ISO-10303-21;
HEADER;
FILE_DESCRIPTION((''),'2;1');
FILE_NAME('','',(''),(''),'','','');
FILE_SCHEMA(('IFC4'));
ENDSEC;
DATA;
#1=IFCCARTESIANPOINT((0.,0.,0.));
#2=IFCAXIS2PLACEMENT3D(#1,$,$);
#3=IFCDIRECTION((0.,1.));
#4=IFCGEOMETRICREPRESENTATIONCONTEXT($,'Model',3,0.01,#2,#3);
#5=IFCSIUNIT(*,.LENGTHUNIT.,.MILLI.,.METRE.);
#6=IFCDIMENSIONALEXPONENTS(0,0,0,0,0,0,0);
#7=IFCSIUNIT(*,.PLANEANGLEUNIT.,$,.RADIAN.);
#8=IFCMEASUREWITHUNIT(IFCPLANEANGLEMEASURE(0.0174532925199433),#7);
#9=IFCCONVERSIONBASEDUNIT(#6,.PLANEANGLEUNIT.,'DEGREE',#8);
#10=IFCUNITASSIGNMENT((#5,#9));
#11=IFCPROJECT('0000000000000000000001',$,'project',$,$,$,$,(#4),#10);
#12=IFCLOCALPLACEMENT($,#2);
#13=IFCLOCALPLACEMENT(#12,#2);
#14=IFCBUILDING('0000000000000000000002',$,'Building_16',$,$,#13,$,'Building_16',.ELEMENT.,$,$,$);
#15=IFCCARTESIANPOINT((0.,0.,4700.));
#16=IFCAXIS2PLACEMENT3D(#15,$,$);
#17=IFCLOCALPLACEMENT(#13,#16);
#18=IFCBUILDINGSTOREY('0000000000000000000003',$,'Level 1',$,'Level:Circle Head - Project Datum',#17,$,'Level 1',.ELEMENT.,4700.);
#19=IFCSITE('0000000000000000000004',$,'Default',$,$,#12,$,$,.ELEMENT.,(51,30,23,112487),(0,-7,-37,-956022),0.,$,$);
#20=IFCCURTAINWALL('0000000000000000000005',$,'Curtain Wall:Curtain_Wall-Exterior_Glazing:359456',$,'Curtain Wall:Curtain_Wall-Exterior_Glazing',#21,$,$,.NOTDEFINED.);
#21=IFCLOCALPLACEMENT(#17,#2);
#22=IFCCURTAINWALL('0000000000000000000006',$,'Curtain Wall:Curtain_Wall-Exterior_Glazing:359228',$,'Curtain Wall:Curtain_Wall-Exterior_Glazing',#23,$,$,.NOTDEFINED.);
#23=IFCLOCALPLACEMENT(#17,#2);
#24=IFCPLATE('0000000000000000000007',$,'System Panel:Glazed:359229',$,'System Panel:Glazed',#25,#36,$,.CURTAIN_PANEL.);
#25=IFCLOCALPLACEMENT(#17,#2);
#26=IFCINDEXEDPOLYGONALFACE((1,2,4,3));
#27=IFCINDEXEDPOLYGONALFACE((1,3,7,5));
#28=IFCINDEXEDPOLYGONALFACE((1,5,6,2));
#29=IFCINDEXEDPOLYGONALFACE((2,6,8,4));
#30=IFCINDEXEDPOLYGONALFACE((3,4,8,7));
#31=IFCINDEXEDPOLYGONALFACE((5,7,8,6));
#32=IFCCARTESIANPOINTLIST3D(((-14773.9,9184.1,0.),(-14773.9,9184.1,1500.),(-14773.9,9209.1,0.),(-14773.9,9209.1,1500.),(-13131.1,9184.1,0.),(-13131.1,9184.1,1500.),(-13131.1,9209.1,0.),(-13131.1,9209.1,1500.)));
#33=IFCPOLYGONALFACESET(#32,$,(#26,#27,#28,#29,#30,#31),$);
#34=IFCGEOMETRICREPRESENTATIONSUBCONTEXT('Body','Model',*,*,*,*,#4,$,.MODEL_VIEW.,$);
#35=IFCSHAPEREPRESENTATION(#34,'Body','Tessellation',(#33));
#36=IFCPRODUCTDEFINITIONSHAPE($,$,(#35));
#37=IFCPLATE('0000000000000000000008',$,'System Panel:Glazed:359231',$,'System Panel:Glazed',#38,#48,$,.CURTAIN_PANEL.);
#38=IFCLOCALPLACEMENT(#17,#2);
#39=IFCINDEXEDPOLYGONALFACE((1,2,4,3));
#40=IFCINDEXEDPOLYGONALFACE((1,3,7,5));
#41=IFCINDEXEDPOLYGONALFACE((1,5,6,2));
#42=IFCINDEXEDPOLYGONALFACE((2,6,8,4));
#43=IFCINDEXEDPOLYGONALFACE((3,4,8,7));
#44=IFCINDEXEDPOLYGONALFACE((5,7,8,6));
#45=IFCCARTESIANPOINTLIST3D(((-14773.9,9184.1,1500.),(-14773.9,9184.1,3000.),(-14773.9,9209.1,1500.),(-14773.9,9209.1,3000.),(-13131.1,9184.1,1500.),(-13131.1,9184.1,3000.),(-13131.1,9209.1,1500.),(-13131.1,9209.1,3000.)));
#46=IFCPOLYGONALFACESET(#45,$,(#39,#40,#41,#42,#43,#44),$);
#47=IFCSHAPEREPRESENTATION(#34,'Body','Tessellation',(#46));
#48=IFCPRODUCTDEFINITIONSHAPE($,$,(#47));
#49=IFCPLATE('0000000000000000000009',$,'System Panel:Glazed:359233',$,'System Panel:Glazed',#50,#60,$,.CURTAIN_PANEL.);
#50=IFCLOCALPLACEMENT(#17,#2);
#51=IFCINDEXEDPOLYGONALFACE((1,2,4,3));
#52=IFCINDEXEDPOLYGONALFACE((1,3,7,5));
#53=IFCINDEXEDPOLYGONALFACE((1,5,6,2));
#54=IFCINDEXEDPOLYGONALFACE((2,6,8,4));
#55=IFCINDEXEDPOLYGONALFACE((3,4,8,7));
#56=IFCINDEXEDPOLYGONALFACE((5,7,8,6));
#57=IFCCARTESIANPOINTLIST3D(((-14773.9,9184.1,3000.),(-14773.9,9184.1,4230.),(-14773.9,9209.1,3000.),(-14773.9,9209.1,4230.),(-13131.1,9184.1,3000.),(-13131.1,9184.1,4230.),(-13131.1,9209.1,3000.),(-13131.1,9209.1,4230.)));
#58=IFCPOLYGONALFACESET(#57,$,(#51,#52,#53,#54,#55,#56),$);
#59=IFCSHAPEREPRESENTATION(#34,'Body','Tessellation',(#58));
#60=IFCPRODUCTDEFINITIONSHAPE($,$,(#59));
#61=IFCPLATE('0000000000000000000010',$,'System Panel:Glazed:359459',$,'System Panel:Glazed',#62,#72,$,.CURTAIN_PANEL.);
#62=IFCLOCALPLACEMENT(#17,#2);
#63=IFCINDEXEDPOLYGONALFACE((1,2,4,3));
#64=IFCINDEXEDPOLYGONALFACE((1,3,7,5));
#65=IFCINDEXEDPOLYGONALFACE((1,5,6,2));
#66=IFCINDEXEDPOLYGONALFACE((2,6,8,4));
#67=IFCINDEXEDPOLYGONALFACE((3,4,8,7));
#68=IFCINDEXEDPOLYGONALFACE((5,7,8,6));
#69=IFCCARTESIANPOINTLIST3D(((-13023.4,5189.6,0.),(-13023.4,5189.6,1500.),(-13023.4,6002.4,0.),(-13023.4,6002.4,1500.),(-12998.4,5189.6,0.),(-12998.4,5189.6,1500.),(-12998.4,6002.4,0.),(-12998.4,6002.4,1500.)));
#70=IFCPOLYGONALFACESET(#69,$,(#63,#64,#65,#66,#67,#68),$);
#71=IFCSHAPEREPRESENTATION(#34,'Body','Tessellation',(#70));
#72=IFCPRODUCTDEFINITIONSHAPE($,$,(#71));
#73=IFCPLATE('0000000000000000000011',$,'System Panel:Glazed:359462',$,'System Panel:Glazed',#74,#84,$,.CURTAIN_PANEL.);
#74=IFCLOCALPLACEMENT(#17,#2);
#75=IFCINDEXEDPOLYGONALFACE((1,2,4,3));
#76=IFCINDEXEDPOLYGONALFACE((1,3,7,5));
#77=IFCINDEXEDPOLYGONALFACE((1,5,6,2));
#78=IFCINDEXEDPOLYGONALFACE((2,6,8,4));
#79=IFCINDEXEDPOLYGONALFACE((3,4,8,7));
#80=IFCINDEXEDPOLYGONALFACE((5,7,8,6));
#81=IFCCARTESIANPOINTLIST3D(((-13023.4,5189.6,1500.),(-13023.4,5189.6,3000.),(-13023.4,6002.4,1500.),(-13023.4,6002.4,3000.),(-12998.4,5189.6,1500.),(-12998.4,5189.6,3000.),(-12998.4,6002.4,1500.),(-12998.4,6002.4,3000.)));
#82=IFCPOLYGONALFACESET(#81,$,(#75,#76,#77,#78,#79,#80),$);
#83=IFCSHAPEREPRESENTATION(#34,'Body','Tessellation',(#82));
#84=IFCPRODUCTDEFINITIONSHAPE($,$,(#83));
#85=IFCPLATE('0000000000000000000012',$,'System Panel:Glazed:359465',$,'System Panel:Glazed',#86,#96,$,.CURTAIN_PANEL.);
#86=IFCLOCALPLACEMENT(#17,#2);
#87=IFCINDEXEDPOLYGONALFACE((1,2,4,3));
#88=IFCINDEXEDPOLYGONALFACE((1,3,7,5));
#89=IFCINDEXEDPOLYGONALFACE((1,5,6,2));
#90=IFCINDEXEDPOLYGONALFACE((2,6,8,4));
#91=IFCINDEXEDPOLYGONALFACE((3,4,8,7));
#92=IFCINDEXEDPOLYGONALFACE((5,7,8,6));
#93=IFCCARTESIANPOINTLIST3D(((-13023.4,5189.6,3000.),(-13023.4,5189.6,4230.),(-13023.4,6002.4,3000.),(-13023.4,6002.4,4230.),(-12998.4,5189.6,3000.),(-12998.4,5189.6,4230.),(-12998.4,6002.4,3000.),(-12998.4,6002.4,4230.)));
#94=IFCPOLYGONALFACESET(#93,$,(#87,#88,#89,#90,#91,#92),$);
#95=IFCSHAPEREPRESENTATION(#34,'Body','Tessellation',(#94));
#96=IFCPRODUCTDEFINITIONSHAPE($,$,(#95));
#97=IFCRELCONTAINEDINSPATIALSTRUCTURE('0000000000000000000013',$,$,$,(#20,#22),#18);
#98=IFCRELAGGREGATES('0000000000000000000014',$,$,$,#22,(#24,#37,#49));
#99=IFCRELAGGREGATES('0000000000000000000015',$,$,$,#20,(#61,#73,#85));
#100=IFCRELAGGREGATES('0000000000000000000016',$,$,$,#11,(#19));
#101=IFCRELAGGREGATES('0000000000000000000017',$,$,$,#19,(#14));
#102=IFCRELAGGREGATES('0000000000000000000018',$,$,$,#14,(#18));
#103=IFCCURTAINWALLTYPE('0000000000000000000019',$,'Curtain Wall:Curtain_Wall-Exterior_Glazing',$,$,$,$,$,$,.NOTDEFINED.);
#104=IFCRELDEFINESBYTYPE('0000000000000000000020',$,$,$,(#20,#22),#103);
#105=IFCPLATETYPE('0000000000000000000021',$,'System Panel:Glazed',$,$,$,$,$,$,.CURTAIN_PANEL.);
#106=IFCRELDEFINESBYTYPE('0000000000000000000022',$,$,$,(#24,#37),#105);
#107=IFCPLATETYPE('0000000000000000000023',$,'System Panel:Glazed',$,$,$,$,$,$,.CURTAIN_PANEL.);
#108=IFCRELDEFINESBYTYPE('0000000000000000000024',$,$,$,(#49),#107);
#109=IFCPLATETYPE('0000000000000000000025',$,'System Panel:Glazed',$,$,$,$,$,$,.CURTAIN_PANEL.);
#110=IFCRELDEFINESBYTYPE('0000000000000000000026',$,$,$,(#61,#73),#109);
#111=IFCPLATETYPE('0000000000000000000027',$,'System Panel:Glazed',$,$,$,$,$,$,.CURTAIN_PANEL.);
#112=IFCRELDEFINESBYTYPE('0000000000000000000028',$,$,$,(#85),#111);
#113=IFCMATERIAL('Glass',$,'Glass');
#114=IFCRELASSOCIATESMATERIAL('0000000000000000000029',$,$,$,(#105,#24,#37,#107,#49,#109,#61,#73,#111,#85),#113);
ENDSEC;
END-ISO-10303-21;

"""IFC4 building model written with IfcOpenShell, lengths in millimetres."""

from ifc_helpers import new_model, entity, si_unit, converted_unit, direction, frame, origin, place, context, subcontext, project, spatial, indexed_curve, outline, extrude, source, transform, mapped, material, type_object, type_shapes, element, aggregate, save


model = new_model("IFC4")

# Units and contexts
model_context = context("Model", 3, precision=0.01, world=origin(), true_north=direction((0.0, 1.0)))
body_context = subcontext(model_context, "Body", "Model", "MODEL_VIEW")
ifc_project = project(units=[si_unit("LENGTHUNIT", "METRE", prefix="MILLI"), converted_unit("PLANEANGLEUNIT", "DEGREE", entity("IfcPlaneAngleMeasure", 0.0174532925199433), si_unit("PLANEANGLEUNIT", "RADIAN"), dimensions=[0, 0, 0, 0, 0, 0, 0])], contexts=[model_context])

# Site, building, storey
site_placement = place(None, origin())
site = spatial("IfcSite", under=ifc_project, at=site_placement, Name="Default", CompositionType="ELEMENT", RefLatitude=(51, 30, 23, 112487), RefLongitude=(0, -7, -37, -956022), RefElevation=0.0)
building_placement = place(site_placement, origin())
building = spatial("IfcBuilding", under=site, at=building_placement, Name="Building_16", LongName="Building_16", CompositionType="ELEMENT")
storey_placement = place(building_placement, frame((0.0, 0.0, 4700.0)))
storey = spatial("IfcBuildingStorey", under=building, at=storey_placement, Name="Level 1", ObjectType="Level:Circle Head - Project Datum", LongName="Level 1", CompositionType="ELEMENT", Elevation=4700.0)

# Curtain wall
curtain_wall_type = type_object("IfcCurtainWallType", Name="Curtain Wall:Curtain_Wall-Exterior_Glazing", PredefinedType="NOTDEFINED")
ifc_material_1 = material(Name="Glass", Category="Glass")
curtain_wall_1_placement = place(storey_placement, frame((0.0, 0.0, -4700.0)))
curtain_wall_1 = element("IfcCurtainWall", 1, at=curtain_wall_1_placement, inside=storey, type_object=curtain_wall_type, Name="Curtain Wall:Curtain_Wall-Exterior_Glazing:359456", ObjectType="Curtain Wall:Curtain_Wall-Exterior_Glazing", PredefinedType="NOTDEFINED")

# Curtain wall, plates
curtain_wall_2_placement = place(storey_placement, frame((0.0, 0.0, -4700.0)))
curtain_wall_2 = element("IfcCurtainWall", 2, at=curtain_wall_2_placement, inside=storey, type_object=curtain_wall_type, Name="Curtain Wall:Curtain_Wall-Exterior_Glazing:359228", ObjectType="Curtain Wall:Curtain_Wall-Exterior_Glazing", PredefinedType="NOTDEFINED")
plate_type_1 = type_object("IfcPlateType", Name="System Panel:Glazed", PredefinedType="CURTAIN_PANEL", material=ifc_material_1)
shared_shape_1 = source(origin(), body_context, "Body", "SweptSolid", [
    extrude(outline(indexed_curve([(-12.5, -821.4), (12.5, -821.4), (12.5, 821.4), (-12.5, 821.4), (-12.5, -821.4)], self_intersect=False)), frame((0.0, 37.0, 0.0), z_axis=(0.0, 0.0, 1.0), x_axis=(0.0, 1.0, 0.0)), (0.0, 0.0, 1.0), 1500.0),
])
type_shapes(plate_type_1, [shared_shape_1])
plate_1_placement = place(curtain_wall_2_placement, frame((-13952.5, 9159.6, 4700.0)))
plate_1 = element("IfcPlate", 3, at=plate_1_placement, type_object=plate_type_1, material=ifc_material_1, Name="System Panel:Glazed:359229", ObjectType="System Panel:Glazed", PredefinedType="CURTAIN_PANEL", context=body_context, shape_type="MappedRepresentation", body=[
    mapped(shared_shape_1, transform((0.0, 0.0, 0.0), scale=1.0)),
])
plate_2_placement = place(curtain_wall_2_placement, frame((-13952.5, 9159.6, 6200.0)))
plate_2 = element("IfcPlate", 4, at=plate_2_placement, type_object=plate_type_1, material=ifc_material_1, Name="System Panel:Glazed:359231", ObjectType="System Panel:Glazed", PredefinedType="CURTAIN_PANEL", context=body_context, shape_type="MappedRepresentation", body=[
    mapped(shared_shape_1, transform((0.0, 0.0, 0.0), scale=1.0)),
])
plate_type_2 = type_object("IfcPlateType", Name="System Panel:Glazed", PredefinedType="CURTAIN_PANEL", material=ifc_material_1)
shared_shape_2 = source(origin(), body_context, "Body", "SweptSolid", [
    extrude(outline(indexed_curve([(-12.5, -821.4), (12.5, -821.4), (12.5, 821.4), (-12.5, 821.4), (-12.5, -821.4)], self_intersect=False)), frame((0.0, 37.0, 0.0), z_axis=(0.0, 0.0, 1.0), x_axis=(0.0, 1.0, 0.0)), (0.0, 0.0, 1.0), 1230.0),
])
type_shapes(plate_type_2, [shared_shape_2])
plate_3_placement = place(curtain_wall_2_placement, frame((-13952.5, 9159.6, 7700.0)))
plate_3 = element("IfcPlate", 5, at=plate_3_placement, type_object=plate_type_2, material=ifc_material_1, Name="System Panel:Glazed:359233", ObjectType="System Panel:Glazed", PredefinedType="CURTAIN_PANEL", context=body_context, shape_type="MappedRepresentation", body=[
    mapped(shared_shape_2, transform((0.0, 0.0, 0.0), scale=1.0)),
])
aggregate(curtain_wall_2, [plate_1, plate_2, plate_3])

# Plates
plate_type_3 = type_object("IfcPlateType", Name="System Panel:Glazed", PredefinedType="CURTAIN_PANEL", material=ifc_material_1)
shared_shape_3 = source(origin(), body_context, "Body", "SweptSolid", [
    extrude(outline(indexed_curve([(-12.5, -406.4), (12.5, -406.4), (12.5, 406.4), (-12.5, 406.4), (-12.5, -406.4)], self_intersect=False)), frame((0.0, 37.0, 0.0), z_axis=(0.0, 0.0, 1.0), x_axis=(0.0, 1.0, 0.0)), (0.0, 0.0, 1.0), 1500.0),
])
type_shapes(plate_type_3, [shared_shape_3])
plate_4_placement = place(curtain_wall_1_placement, frame((-12973.9, 5596.0, 4700.0), z_axis=(0.0, 0.0, 1.0), x_axis=(0.0, 1.0, 0.0)))
plate_4 = element("IfcPlate", 6, at=plate_4_placement, type_object=plate_type_3, material=ifc_material_1, Name="System Panel:Glazed:359459", ObjectType="System Panel:Glazed", PredefinedType="CURTAIN_PANEL", context=body_context, shape_type="MappedRepresentation", body=[
    mapped(shared_shape_3, transform((0.0, 0.0, 0.0), scale=1.0)),
])
plate_5_placement = place(curtain_wall_1_placement, frame((-12973.9, 5596.0, 6200.0), z_axis=(0.0, 0.0, 1.0), x_axis=(0.0, 1.0, 0.0)))
plate_5 = element("IfcPlate", 7, at=plate_5_placement, type_object=plate_type_3, material=ifc_material_1, Name="System Panel:Glazed:359462", ObjectType="System Panel:Glazed", PredefinedType="CURTAIN_PANEL", context=body_context, shape_type="MappedRepresentation", body=[
    mapped(shared_shape_3, transform((0.0, 0.0, 0.0), scale=1.0)),
])
plate_type_4 = type_object("IfcPlateType", Name="System Panel:Glazed", PredefinedType="CURTAIN_PANEL", material=ifc_material_1)
shared_shape_4 = source(origin(), body_context, "Body", "SweptSolid", [
    extrude(outline(indexed_curve([(-12.5, -406.4), (12.5, -406.4), (12.5, 406.4), (-12.5, 406.4), (-12.5, -406.4)], self_intersect=False)), frame((0.0, 37.0, 0.0), z_axis=(0.0, 0.0, 1.0), x_axis=(0.0, 1.0, 0.0)), (0.0, 0.0, 1.0), 1230.0),
])
type_shapes(plate_type_4, [shared_shape_4])
plate_6_placement = place(curtain_wall_1_placement, frame((-12973.9, 5596.0, 7700.0), z_axis=(0.0, 0.0, 1.0), x_axis=(0.0, 1.0, 0.0)))
plate_6 = element("IfcPlate", 8, at=plate_6_placement, type_object=plate_type_4, material=ifc_material_1, Name="System Panel:Glazed:359465", ObjectType="System Panel:Glazed", PredefinedType="CURTAIN_PANEL", context=body_context, shape_type="MappedRepresentation", body=[
    mapped(shared_shape_4, transform((0.0, 0.0, 0.0), scale=1.0)),
])
aggregate(curtain_wall_1, [plate_4, plate_5, plate_6])

save(model, "model.ifc")
